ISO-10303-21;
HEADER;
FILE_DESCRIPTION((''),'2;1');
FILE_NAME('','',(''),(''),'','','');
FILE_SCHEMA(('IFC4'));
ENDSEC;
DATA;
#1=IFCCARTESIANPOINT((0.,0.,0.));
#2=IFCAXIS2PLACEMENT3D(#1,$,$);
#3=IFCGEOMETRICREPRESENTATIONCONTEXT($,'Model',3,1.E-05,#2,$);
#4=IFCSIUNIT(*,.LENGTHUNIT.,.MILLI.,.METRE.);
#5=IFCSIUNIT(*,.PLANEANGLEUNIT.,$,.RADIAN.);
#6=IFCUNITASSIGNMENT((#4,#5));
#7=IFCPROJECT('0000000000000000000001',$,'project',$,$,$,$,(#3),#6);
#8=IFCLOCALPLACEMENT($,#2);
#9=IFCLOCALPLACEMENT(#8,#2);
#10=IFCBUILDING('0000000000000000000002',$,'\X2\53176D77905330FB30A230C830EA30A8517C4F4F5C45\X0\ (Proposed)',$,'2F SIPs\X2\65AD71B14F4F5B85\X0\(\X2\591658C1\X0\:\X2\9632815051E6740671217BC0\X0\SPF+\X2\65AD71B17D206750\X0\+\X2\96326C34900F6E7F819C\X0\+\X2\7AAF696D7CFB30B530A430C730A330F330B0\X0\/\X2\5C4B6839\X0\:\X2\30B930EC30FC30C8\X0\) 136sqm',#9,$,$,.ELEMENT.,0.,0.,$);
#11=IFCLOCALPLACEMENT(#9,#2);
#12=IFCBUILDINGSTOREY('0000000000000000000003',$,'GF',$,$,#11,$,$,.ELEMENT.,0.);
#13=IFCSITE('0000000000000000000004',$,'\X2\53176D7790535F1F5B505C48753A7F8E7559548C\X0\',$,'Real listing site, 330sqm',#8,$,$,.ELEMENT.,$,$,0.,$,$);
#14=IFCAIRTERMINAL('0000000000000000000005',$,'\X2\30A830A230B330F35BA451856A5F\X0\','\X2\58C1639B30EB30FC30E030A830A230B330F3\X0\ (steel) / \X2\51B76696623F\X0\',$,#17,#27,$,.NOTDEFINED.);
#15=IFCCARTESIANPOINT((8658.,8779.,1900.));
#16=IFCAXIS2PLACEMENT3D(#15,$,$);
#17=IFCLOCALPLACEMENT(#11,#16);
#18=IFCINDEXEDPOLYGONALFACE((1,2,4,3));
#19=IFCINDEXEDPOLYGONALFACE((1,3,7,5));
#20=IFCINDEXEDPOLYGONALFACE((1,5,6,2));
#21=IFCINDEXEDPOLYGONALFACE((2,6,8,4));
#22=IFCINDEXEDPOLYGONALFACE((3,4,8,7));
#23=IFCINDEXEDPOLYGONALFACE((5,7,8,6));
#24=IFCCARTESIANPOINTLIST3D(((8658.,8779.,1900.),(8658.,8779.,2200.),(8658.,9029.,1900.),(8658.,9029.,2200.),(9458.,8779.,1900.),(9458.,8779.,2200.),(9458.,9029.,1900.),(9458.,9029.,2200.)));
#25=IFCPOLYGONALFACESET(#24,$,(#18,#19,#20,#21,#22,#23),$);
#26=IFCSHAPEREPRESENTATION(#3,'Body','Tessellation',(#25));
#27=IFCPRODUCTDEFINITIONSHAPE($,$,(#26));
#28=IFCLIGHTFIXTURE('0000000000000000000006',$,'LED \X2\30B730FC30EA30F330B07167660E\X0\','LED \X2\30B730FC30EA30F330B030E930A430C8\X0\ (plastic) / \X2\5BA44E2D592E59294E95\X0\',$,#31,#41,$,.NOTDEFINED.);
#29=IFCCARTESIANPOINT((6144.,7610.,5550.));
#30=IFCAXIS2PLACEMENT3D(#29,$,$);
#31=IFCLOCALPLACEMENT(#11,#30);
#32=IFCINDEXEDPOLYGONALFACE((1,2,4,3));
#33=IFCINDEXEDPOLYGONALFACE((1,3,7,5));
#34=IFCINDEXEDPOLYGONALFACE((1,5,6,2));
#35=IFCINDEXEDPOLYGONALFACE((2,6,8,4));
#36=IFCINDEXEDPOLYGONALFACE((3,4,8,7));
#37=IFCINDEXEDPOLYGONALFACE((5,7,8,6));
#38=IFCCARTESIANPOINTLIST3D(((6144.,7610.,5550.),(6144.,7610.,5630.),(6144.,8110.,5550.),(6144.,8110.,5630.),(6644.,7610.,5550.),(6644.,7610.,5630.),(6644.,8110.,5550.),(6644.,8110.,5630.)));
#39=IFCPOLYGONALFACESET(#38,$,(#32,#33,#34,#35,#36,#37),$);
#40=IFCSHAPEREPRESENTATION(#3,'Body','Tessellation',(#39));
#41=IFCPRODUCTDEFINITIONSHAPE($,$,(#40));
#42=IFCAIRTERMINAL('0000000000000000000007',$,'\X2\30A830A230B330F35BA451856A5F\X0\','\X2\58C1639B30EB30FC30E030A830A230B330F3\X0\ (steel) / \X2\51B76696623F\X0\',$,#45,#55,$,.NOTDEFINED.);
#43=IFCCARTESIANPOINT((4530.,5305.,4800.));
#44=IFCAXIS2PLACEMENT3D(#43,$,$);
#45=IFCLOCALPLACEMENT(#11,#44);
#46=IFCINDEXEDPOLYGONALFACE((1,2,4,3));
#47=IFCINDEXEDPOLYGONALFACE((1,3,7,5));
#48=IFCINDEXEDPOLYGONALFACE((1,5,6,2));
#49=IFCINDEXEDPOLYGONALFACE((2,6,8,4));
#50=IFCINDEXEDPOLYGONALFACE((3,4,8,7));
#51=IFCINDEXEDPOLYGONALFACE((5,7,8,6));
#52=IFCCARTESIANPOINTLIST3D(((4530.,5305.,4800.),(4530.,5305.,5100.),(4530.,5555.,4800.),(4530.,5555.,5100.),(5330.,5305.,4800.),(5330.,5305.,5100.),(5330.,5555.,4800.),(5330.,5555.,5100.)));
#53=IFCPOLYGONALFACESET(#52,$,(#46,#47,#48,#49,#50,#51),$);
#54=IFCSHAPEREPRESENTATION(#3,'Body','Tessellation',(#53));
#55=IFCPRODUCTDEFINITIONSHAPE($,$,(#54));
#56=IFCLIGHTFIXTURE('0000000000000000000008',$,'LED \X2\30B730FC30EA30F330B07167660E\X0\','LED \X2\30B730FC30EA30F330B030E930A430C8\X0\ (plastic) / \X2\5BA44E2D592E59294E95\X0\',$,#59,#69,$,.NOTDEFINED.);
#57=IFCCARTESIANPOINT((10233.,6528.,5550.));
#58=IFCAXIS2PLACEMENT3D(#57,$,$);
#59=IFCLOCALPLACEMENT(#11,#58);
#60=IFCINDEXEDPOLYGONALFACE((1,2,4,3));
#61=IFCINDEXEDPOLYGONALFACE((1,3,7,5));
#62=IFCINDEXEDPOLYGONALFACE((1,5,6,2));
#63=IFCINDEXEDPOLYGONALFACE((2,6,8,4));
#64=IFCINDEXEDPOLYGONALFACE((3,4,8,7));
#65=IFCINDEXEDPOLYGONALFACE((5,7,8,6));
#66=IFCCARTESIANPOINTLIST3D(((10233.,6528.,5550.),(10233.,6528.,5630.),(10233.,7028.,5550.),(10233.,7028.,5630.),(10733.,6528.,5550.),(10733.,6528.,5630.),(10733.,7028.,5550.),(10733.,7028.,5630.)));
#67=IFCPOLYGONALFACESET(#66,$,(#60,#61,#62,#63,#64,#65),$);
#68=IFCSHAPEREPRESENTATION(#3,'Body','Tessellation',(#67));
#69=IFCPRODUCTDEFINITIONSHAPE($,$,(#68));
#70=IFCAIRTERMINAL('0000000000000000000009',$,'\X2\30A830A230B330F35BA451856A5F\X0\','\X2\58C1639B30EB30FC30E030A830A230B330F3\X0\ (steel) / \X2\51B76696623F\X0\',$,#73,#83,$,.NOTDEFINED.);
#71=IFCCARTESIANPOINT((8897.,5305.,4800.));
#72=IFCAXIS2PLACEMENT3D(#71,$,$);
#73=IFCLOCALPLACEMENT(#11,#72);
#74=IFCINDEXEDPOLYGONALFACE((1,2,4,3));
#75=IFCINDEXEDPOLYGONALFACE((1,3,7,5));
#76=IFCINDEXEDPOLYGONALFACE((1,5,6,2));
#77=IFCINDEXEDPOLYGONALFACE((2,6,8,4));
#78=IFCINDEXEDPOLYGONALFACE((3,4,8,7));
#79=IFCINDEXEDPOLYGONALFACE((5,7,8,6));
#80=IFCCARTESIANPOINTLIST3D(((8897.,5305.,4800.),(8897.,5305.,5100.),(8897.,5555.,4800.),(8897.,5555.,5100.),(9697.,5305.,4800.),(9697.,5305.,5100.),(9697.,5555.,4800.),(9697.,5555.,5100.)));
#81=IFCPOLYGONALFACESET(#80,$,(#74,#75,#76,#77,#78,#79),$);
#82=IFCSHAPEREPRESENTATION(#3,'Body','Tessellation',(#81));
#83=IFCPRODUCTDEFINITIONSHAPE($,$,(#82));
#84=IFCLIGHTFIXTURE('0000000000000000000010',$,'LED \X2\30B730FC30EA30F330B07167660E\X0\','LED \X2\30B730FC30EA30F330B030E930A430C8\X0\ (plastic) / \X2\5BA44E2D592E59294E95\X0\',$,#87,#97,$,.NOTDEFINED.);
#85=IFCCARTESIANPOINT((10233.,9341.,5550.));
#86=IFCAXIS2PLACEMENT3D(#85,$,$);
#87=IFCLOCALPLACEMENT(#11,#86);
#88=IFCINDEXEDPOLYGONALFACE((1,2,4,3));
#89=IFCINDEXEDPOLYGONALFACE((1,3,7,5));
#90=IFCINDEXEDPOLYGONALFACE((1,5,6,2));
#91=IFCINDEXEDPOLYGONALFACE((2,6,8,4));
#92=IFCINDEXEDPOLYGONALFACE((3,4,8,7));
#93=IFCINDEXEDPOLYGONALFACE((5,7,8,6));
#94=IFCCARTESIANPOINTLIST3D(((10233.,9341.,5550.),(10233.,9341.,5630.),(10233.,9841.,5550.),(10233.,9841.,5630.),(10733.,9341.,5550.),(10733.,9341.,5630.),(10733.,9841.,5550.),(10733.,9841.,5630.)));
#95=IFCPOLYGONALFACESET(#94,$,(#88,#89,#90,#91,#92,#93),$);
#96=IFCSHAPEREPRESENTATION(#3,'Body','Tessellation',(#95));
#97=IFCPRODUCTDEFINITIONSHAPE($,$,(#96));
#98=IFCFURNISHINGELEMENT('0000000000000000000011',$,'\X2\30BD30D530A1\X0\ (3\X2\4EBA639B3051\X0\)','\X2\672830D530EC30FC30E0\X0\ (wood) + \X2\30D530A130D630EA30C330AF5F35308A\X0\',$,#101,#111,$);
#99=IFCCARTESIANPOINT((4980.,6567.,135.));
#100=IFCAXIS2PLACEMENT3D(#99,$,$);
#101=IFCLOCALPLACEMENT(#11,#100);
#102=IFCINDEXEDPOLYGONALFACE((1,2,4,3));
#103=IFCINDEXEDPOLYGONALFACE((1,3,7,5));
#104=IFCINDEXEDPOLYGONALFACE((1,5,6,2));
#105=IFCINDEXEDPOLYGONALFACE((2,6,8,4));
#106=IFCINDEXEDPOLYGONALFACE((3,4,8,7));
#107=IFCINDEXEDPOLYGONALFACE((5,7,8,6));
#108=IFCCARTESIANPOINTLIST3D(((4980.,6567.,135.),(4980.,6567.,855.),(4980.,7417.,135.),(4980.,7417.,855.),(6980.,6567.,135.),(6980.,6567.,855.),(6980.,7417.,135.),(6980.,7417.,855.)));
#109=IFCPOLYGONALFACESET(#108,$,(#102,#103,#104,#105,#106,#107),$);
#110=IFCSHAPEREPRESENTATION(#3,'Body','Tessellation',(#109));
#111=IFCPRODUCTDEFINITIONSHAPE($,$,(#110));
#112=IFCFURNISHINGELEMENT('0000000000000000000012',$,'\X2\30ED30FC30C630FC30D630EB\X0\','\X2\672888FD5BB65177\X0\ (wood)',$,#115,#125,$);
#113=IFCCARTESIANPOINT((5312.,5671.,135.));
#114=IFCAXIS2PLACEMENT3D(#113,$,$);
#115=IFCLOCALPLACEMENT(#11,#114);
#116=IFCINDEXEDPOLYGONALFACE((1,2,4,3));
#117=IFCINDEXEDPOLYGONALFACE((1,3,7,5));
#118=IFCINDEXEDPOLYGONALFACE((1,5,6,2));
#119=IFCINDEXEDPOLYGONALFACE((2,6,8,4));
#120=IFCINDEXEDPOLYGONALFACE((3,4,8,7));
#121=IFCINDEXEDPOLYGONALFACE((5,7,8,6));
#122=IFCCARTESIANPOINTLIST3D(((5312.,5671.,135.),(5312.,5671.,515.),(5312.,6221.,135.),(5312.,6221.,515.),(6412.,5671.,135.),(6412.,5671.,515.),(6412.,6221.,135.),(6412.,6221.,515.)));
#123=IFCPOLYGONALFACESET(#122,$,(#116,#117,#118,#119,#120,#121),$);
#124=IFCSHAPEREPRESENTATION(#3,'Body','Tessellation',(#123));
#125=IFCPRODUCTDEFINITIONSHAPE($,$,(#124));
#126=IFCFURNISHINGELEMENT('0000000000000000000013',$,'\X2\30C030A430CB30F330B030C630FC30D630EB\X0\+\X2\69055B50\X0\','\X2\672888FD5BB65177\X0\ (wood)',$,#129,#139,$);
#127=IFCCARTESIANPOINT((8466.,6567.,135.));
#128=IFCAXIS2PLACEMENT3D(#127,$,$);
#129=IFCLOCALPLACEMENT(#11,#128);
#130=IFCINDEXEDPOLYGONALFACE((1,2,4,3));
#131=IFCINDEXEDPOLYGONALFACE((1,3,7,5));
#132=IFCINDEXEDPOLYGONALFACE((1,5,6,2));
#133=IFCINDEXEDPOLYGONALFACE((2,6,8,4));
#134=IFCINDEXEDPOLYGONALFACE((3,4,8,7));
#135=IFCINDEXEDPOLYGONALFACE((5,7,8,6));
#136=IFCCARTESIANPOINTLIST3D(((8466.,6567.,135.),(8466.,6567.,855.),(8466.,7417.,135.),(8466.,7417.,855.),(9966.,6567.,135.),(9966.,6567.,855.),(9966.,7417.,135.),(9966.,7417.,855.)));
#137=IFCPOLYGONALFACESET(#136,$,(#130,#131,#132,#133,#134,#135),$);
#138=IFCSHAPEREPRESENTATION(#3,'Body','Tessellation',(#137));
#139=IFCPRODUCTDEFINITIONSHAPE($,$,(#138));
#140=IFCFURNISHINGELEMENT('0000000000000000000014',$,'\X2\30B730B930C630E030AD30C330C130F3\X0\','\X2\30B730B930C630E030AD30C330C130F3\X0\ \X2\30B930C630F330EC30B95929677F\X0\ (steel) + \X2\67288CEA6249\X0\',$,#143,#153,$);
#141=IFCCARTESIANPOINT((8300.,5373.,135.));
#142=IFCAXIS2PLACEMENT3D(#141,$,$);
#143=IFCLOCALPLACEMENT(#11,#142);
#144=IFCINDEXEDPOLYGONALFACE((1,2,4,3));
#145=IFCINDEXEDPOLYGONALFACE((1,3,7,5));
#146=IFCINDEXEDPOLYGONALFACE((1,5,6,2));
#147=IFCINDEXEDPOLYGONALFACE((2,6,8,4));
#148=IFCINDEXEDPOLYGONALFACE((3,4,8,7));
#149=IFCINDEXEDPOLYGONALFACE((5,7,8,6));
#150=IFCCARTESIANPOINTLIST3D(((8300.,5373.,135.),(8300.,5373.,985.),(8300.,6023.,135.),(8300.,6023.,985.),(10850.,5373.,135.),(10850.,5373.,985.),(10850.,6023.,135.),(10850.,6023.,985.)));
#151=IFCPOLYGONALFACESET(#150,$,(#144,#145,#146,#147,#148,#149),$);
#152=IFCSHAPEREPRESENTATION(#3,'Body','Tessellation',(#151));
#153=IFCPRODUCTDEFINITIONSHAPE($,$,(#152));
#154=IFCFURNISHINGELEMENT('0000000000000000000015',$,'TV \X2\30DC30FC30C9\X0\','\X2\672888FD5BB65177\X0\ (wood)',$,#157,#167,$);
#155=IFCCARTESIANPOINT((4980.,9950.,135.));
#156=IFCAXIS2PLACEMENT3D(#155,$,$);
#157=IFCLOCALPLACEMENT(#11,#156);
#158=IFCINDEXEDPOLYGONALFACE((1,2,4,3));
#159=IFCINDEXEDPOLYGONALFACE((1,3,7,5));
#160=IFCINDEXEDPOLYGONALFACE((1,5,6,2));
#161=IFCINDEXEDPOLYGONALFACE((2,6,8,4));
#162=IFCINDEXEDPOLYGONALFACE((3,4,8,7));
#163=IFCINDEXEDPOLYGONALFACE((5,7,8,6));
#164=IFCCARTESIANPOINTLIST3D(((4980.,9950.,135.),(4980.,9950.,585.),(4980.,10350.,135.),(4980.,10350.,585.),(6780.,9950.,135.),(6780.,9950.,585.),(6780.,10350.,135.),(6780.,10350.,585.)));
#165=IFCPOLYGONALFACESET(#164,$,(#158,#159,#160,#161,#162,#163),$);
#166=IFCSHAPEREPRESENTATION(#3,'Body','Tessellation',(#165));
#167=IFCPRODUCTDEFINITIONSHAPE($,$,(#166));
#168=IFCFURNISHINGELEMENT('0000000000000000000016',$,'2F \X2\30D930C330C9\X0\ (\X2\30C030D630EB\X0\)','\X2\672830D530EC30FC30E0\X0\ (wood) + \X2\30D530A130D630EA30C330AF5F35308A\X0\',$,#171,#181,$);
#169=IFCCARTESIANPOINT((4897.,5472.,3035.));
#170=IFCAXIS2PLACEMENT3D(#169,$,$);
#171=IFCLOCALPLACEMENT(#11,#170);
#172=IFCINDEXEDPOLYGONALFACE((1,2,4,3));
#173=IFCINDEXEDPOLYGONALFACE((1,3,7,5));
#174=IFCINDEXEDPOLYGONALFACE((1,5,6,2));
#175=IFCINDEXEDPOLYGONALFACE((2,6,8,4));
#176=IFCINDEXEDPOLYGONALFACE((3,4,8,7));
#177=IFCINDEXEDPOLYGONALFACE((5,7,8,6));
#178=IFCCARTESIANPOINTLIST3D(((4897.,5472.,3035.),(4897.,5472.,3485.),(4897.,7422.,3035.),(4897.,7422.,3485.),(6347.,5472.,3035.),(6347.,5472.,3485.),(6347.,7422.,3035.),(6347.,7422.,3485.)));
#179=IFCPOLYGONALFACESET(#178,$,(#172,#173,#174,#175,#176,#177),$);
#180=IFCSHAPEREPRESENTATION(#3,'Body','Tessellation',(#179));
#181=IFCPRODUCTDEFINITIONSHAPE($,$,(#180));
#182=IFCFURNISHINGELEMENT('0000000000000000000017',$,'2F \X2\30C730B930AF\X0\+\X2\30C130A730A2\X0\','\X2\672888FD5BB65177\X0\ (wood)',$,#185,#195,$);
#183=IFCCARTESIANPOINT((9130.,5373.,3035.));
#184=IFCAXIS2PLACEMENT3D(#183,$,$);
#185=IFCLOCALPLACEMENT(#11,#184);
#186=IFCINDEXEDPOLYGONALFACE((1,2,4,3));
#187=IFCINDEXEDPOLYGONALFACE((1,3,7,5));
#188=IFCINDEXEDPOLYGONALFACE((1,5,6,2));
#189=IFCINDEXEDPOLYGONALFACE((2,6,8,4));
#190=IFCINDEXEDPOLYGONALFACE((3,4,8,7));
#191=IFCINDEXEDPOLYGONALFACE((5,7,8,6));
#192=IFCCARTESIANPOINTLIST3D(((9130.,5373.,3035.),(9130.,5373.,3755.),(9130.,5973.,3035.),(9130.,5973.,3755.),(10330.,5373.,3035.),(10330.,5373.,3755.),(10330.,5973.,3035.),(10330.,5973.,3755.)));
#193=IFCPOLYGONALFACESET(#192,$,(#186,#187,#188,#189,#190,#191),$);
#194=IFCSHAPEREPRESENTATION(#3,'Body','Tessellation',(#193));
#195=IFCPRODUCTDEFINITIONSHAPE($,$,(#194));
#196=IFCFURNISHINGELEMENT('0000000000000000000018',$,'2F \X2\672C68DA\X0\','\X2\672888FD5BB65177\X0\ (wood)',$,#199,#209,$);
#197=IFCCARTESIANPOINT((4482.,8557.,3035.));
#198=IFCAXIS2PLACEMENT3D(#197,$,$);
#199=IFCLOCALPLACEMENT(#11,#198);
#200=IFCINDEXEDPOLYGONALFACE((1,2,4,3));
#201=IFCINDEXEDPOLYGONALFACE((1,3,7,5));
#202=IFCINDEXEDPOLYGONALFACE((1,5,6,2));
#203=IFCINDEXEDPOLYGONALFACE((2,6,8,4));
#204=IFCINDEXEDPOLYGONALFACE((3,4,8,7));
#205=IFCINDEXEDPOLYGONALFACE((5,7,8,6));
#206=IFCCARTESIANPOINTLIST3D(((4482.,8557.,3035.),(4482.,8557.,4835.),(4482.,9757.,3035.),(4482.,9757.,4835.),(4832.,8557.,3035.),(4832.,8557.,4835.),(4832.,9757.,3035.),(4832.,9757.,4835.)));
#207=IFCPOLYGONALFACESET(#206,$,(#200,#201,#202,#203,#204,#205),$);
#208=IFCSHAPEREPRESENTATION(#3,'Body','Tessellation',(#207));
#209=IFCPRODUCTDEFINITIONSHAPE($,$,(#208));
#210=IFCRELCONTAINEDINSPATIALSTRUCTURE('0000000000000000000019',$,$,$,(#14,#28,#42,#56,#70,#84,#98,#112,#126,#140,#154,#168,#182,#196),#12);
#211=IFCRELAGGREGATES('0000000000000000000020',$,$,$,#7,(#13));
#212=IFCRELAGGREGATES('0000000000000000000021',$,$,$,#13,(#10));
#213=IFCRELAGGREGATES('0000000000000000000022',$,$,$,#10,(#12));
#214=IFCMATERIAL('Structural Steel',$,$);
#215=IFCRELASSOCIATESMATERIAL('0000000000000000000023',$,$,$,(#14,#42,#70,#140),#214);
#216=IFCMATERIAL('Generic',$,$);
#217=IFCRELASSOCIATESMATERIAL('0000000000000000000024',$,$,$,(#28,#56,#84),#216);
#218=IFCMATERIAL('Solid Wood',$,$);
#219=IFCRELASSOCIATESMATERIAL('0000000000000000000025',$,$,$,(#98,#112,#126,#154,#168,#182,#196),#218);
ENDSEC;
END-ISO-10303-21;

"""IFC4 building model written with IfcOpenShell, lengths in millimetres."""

from ifc_helpers import new_model, si_unit, frame, frame_2d, origin, place, context, project, spatial, rectangle, extrude, material, element, save


model = new_model("IFC4")

# Units and contexts
model_context = context("Model", 3, precision=1e-05, world=origin())
ifc_project = project(units=[si_unit("LENGTHUNIT", "METRE", prefix="MILLI"), si_unit("PLANEANGLEUNIT", "RADIAN")], contexts=[model_context])

# Site, building, storey
site_placement = place(None, origin())
site = spatial("IfcSite", under=ifc_project, at=site_placement, Name="北海道弟子屈町美留和", ObjectType="Real listing site, 330sqm", CompositionType="ELEMENT", RefElevation=0.0)
building_placement = place(site_placement, origin())
building = spatial("IfcBuilding", under=site, at=building_placement, Name="北海道・アトリエ兼住居 (Proposed)", ObjectType="2F SIPs断熱住宅(外壁:防腐処理無節SPF+断熱素材+防水透湿膜+窯業系サイディング/屋根:スレート) 136sqm", CompositionType="ELEMENT", ElevationOfRefHeight=0.0, ElevationOfTerrain=0.0)
storey_placement = place(building_placement, origin())
storey = spatial("IfcBuildingStorey", under=building, at=storey_placement, Name="GF", CompositionType="ELEMENT", Elevation=0.0)

# Shared definitions
ifc_material_1 = material(Name="Solid Wood")

# Shared definitions
ifc_material_2 = material(Name="Structural Steel")

# Shared definitions
ifc_material_3 = material(Name="Generic")

# Air terminal
air_terminal_1_placement = place(storey_placement, frame((8658.0, 8779.0, 1900.0)))
element("IfcAirTerminal", 1, at=air_terminal_1_placement, inside=storey, material=ifc_material_2, Name="エアコン室内機", Description="壁掛ルームエアコン (steel) / 冷暖房", PredefinedType="NOTDEFINED", context=model_context, shape_type="SweptSolid", body=[
    extrude(rectangle(XDim=800.0, YDim=250.0, at=frame_2d((400.0, 125.0))), frame((8658.0, 8779.0, 1900.0)), (0.0, 0.0, 1.0), 300.0),
])

# Light fixture
light_fixture_1_placement = place(storey_placement, frame((6144.0, 7610.0, 5550.0)))
element("IfcLightFixture", 2, at=light_fixture_1_placement, inside=storey, material=ifc_material_3, Name="LED シーリング照明", Description="LED シーリングライト (plastic) / 室中央天井", PredefinedType="NOTDEFINED", context=model_context, shape_type="SweptSolid", body=[
    extrude(rectangle(XDim=500.0, YDim=500.0, at=frame_2d((250.0, 250.0))), frame((6144.0, 7610.0, 5550.0)), (0.0, 0.0, 1.0), 80.0),
])

# Air terminal
air_terminal_2_placement = place(storey_placement, frame((4530.0, 5305.0, 4800.0)))
element("IfcAirTerminal", 3, at=air_terminal_2_placement, inside=storey, material=ifc_material_2, Name="エアコン室内機", Description="壁掛ルームエアコン (steel) / 冷暖房", PredefinedType="NOTDEFINED", context=model_context, shape_type="SweptSolid", body=[
    extrude(rectangle(XDim=800.0, YDim=250.0, at=frame_2d((400.0, 125.0))), frame((4530.0, 5305.0, 4800.0)), (0.0, 0.0, 1.0), 300.0),
])

# Light fixture
light_fixture_2_placement = place(storey_placement, frame((10233.0, 6528.0, 5550.0)))
element("IfcLightFixture", 4, at=light_fixture_2_placement, inside=storey, material=ifc_material_3, Name="LED シーリング照明", Description="LED シーリングライト (plastic) / 室中央天井", PredefinedType="NOTDEFINED", context=model_context, shape_type="SweptSolid", body=[
    extrude(rectangle(XDim=500.0, YDim=500.0, at=frame_2d((250.0, 250.0))), frame((10233.0, 6528.0, 5550.0)), (0.0, 0.0, 1.0), 80.0),
])

# Air terminal
air_terminal_3_placement = place(storey_placement, frame((8897.0, 5305.0, 4800.0)))
element("IfcAirTerminal", 5, at=air_terminal_3_placement, inside=storey, material=ifc_material_2, Name="エアコン室内機", Description="壁掛ルームエアコン (steel) / 冷暖房", PredefinedType="NOTDEFINED", context=model_context, shape_type="SweptSolid", body=[
    extrude(rectangle(XDim=800.0, YDim=250.0, at=frame_2d((400.0, 125.0))), frame((8897.0, 5305.0, 4800.0)), (0.0, 0.0, 1.0), 300.0),
])

# Light fixture
light_fixture_3_placement = place(storey_placement, frame((10233.0, 9341.0, 5550.0)))
element("IfcLightFixture", 6, at=light_fixture_3_placement, inside=storey, material=ifc_material_3, Name="LED シーリング照明", Description="LED シーリングライト (plastic) / 室中央天井", PredefinedType="NOTDEFINED", context=model_context, shape_type="SweptSolid", body=[
    extrude(rectangle(XDim=500.0, YDim=500.0, at=frame_2d((250.0, 250.0))), frame((10233.0, 9341.0, 5550.0)), (0.0, 0.0, 1.0), 80.0),
])

# Furnishing elements
furnishing_1_placement = place(storey_placement, frame((4980.0, 6567.0, 135.0)))
element("IfcFurnishingElement", 7, at=furnishing_1_placement, inside=storey, material=ifc_material_1, Name="ソファ (3人掛け)", Description="木フレーム (wood) + ファブリック張り", context=model_context, shape_type="SweptSolid", body=[
    extrude(rectangle(XDim=2000.0, YDim=850.0, at=frame_2d((1000.0, 425.0))), frame((4980.0, 6567.0, 135.0)), (0.0, 0.0, 1.0), 720.0),
])
furnishing_2_placement = place(storey_placement, frame((5312.0, 5671.0, 135.0)))
element("IfcFurnishingElement", 8, at=furnishing_2_placement, inside=storey, material=ifc_material_1, Name="ローテーブル", Description="木製家具 (wood)", context=model_context, shape_type="SweptSolid", body=[
    extrude(rectangle(XDim=1100.0, YDim=550.0, at=frame_2d((550.0, 275.0))), frame((5312.0, 5671.0, 135.0)), (0.0, 0.0, 1.0), 380.0),
])
furnishing_3_placement = place(storey_placement, frame((8466.0, 6567.0, 135.0)))
element("IfcFurnishingElement", 9, at=furnishing_3_placement, inside=storey, material=ifc_material_1, Name="ダイニングテーブル+椅子", Description="木製家具 (wood)", context=model_context, shape_type="SweptSolid", body=[
    extrude(rectangle(XDim=1500.0, YDim=850.0, at=frame_2d((750.0, 425.0))), frame((8466.0, 6567.0, 135.0)), (0.0, 0.0, 1.0), 720.0),
])
furnishing_4_placement = place(storey_placement, frame((8300.0, 5373.0, 135.0)))
element("IfcFurnishingElement", 10, at=furnishing_4_placement, inside=storey, material=ifc_material_2, Name="システムキッチン", Description="システムキッチン ステンレス天板 (steel) + 木質扉", context=model_context, shape_type="SweptSolid", body=[
    extrude(rectangle(XDim=2550.0, YDim=650.0, at=frame_2d((1275.0, 325.0))), frame((8300.0, 5373.0, 135.0)), (0.0, 0.0, 1.0), 850.0),
])
furnishing_5_placement = place(storey_placement, frame((4980.0, 9950.0, 135.0)))
element("IfcFurnishingElement", 11, at=furnishing_5_placement, inside=storey, material=ifc_material_1, Name="TV ボード", Description="木製家具 (wood)", context=model_context, shape_type="SweptSolid", body=[
    extrude(rectangle(XDim=1800.0, YDim=400.0, at=frame_2d((900.0, 200.0))), frame((4980.0, 9950.0, 135.0)), (0.0, 0.0, 1.0), 450.0),
])
furnishing_6_placement = place(storey_placement, frame((4897.0, 5472.0, 3035.0)))
element("IfcFurnishingElement", 12, at=furnishing_6_placement, inside=storey, material=ifc_material_1, Name="2F ベッド (ダブル)", Description="木フレーム (wood) + ファブリック張り", context=model_context, shape_type="SweptSolid", body=[
    extrude(rectangle(XDim=1450.0, YDim=1950.0, at=frame_2d((725.0, 975.0))), frame((4897.0, 5472.0, 3035.0)), (0.0, 0.0, 1.0), 450.0),
])
furnishing_7_placement = place(storey_placement, frame((9130.0, 5373.0, 3035.0)))
element("IfcFurnishingElement", 13, at=furnishing_7_placement, inside=storey, material=ifc_material_1, Name="2F デスク+チェア", Description="木製家具 (wood)", context=model_context, shape_type="SweptSolid", body=[
    extrude(rectangle(XDim=1200.0, YDim=600.0, at=frame_2d((600.0, 300.0))), frame((9130.0, 5373.0, 3035.0)), (0.0, 0.0, 1.0), 720.0),
])
furnishing_8_placement = place(storey_placement, frame((4482.0, 8557.0, 3035.0)))
element("IfcFurnishingElement", 14, at=furnishing_8_placement, inside=storey, material=ifc_material_1, Name="2F 本棚", Description="木製家具 (wood)", context=model_context, shape_type="SweptSolid", body=[
    extrude(rectangle(XDim=350.0, YDim=1200.0, at=frame_2d((175.0, 600.0))), frame((4482.0, 8557.0, 3035.0)), (0.0, 0.0, 1.0), 1800.0),
])

save(model, "model.ifc")
